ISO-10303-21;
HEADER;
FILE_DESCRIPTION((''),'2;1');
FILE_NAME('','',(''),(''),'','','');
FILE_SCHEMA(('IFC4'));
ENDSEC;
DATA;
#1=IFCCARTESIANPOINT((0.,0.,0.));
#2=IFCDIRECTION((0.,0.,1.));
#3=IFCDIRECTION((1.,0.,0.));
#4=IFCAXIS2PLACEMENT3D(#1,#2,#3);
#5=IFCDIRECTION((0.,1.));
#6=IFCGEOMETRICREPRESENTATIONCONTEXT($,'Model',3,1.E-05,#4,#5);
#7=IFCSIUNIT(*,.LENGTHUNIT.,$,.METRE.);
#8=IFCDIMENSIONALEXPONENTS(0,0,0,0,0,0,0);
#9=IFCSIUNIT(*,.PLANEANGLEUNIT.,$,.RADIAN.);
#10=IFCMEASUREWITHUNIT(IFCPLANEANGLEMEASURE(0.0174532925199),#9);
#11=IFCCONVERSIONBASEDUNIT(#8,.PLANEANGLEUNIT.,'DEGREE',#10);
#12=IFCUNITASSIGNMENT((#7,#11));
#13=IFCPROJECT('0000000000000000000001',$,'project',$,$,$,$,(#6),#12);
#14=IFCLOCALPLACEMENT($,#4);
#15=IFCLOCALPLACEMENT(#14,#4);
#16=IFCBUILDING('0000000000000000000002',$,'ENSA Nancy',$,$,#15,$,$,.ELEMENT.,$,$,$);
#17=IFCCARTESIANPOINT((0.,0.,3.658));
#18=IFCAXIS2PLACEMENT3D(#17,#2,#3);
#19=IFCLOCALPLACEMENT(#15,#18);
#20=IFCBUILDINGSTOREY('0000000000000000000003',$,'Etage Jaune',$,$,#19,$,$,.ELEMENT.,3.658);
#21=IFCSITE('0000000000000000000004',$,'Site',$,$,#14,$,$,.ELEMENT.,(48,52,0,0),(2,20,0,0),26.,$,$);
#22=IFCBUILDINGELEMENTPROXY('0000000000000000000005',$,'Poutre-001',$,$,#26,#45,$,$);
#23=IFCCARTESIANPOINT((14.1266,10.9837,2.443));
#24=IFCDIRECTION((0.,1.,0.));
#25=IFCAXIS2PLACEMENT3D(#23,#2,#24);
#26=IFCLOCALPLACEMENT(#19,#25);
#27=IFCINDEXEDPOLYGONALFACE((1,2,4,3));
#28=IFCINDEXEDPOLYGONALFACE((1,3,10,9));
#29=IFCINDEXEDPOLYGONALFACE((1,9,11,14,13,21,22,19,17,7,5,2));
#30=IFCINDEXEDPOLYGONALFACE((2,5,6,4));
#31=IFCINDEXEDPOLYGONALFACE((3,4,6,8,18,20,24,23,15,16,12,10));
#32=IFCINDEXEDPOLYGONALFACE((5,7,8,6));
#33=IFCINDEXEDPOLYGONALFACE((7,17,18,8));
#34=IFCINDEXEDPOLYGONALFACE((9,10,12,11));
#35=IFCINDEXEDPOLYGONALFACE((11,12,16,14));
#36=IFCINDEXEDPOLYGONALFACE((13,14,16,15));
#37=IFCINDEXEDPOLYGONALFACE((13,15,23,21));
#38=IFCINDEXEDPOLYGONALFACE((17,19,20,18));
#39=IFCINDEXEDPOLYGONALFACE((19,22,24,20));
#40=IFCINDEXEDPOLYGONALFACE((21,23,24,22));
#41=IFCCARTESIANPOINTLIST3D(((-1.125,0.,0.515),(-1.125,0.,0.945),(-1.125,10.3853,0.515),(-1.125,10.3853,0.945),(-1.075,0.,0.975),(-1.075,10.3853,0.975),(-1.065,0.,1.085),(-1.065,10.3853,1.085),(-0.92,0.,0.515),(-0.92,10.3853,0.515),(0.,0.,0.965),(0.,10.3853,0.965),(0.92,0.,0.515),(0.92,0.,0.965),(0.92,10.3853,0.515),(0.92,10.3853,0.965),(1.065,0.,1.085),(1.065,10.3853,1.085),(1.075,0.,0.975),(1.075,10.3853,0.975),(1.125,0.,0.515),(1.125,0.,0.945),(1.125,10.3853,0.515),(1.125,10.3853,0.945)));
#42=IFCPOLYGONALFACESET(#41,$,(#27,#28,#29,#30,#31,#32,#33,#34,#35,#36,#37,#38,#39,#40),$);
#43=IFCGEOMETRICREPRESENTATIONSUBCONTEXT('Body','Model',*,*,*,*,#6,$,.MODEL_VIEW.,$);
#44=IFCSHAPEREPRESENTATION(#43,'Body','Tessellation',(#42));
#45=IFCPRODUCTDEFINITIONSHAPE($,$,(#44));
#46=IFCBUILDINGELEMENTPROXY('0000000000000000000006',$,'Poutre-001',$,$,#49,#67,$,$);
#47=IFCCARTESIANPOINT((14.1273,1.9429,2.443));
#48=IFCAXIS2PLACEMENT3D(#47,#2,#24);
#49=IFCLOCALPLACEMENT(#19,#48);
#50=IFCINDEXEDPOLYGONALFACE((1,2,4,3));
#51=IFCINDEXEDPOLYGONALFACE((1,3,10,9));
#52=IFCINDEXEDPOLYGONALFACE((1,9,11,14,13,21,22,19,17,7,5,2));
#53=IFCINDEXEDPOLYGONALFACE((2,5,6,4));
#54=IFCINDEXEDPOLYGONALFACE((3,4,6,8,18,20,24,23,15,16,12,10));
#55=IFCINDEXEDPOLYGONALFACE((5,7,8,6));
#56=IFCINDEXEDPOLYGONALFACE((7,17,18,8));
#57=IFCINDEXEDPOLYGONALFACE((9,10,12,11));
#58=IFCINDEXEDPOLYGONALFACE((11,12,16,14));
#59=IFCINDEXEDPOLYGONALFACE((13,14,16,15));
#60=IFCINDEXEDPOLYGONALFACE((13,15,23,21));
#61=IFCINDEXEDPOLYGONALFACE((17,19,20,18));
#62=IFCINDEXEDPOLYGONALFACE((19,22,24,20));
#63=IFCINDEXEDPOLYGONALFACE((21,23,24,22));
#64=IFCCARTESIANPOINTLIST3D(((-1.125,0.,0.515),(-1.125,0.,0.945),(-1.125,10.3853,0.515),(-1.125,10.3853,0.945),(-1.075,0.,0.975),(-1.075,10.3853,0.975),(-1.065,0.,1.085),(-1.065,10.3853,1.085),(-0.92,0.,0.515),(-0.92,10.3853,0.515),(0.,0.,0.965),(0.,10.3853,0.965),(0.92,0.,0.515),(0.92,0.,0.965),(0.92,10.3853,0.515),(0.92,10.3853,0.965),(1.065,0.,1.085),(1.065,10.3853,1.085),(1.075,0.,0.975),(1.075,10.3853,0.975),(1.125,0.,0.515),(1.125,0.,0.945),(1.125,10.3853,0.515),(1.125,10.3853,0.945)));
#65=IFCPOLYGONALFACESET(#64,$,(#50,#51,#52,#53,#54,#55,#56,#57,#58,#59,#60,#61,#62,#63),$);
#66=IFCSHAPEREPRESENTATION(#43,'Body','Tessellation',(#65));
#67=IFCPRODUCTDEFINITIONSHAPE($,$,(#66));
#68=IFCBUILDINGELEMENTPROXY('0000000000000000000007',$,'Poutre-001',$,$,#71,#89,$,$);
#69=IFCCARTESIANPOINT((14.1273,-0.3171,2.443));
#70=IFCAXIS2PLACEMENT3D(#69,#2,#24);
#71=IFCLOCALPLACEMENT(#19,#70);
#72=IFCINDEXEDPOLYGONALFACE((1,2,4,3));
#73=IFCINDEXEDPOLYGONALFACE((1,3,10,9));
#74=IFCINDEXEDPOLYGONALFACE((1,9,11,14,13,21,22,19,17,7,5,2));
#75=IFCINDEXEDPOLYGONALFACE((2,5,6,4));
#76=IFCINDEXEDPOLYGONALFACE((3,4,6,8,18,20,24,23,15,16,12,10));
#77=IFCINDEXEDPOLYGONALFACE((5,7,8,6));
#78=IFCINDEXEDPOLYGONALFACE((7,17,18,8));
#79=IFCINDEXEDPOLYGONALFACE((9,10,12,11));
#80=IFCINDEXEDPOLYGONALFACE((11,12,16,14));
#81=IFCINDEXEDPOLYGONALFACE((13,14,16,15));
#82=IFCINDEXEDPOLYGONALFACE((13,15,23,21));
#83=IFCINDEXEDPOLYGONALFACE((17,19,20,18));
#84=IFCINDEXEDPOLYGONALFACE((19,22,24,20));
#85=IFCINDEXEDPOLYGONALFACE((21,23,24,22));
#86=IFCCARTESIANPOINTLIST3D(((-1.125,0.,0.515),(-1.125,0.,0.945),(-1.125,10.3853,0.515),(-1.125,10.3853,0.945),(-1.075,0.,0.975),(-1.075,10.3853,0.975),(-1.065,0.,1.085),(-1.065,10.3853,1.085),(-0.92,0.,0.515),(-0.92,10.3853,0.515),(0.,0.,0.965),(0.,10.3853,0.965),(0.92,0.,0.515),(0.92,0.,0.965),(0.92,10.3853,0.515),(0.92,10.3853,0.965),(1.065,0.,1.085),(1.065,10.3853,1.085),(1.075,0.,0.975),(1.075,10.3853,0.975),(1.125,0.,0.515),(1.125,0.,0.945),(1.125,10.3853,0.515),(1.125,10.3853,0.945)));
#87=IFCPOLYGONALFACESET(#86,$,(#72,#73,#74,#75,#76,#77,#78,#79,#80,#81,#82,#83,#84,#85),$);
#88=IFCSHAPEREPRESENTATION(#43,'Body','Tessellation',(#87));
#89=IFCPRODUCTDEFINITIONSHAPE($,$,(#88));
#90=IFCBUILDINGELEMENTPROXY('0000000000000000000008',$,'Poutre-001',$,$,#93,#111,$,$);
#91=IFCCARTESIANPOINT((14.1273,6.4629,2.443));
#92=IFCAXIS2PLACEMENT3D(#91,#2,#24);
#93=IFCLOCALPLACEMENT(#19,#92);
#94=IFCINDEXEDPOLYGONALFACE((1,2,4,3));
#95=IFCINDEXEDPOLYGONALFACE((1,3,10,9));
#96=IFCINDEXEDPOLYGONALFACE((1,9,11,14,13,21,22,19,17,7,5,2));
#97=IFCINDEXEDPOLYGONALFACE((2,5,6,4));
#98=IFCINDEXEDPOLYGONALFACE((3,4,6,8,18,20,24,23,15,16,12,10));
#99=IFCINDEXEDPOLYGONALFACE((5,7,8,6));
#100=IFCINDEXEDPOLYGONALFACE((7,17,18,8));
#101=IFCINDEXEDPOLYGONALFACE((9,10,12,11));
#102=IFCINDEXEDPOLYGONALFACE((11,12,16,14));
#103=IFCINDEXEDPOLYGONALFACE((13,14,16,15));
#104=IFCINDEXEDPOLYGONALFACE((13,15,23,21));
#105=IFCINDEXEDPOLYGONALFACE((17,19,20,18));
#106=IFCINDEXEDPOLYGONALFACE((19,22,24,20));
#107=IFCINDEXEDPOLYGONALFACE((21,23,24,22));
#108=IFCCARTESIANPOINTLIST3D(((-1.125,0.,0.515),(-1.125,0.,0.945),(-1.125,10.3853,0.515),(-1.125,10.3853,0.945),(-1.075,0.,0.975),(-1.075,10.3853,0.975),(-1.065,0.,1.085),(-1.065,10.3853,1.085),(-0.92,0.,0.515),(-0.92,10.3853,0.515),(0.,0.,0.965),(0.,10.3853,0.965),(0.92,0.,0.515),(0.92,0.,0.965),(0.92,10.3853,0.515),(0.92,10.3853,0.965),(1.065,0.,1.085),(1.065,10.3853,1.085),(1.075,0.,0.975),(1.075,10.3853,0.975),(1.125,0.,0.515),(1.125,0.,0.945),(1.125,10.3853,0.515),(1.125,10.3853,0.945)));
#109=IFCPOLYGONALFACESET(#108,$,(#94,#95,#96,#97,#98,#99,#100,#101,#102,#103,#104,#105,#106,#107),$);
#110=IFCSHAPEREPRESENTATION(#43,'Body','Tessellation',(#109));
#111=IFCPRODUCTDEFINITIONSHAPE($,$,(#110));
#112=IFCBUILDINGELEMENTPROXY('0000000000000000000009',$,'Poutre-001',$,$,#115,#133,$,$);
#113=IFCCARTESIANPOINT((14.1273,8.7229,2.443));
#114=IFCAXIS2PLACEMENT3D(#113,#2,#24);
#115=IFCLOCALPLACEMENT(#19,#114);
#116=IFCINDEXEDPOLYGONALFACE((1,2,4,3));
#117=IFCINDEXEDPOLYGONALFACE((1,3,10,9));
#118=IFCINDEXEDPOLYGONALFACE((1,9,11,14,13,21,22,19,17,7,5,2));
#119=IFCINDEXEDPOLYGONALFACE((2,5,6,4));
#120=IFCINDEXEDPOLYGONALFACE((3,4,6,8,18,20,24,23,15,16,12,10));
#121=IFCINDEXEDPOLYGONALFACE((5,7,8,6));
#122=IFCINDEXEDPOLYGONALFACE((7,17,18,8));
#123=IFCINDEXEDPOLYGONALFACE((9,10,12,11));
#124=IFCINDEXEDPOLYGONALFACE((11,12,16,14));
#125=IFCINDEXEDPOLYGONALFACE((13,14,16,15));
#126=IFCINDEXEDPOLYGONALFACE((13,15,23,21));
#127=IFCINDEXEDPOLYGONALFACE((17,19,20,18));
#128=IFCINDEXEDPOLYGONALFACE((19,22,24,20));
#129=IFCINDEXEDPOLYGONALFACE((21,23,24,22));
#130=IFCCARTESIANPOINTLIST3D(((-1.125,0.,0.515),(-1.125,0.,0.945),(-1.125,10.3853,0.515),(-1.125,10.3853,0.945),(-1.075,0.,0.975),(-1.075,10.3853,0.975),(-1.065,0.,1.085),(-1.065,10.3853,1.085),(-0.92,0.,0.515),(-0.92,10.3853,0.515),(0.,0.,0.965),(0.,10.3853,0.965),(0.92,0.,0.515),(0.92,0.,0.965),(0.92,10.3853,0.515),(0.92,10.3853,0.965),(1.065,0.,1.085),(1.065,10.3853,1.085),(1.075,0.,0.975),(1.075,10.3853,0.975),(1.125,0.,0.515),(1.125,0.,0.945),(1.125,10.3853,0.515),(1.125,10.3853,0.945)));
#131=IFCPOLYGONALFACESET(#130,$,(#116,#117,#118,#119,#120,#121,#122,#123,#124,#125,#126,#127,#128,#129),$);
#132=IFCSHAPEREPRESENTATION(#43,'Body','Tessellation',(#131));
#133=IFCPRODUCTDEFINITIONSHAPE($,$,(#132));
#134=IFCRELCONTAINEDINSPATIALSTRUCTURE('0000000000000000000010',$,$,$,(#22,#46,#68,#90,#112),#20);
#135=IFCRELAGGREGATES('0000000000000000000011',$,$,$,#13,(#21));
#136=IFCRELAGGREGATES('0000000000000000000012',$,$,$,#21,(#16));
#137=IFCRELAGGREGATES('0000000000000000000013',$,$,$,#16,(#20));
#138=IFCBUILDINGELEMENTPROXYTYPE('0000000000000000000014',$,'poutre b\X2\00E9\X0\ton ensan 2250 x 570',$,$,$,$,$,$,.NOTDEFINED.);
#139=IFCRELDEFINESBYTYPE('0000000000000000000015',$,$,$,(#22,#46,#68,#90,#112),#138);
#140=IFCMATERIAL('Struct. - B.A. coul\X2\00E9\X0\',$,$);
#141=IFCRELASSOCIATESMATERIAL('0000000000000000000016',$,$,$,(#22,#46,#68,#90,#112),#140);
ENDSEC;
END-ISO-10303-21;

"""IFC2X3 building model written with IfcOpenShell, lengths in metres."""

from ifc_helpers import new_model, entity, si_unit, converted_unit, direction, frame, origin_with_axes, place, context, subcontext, project, spatial, polyline, outline, extrude, material, type_object, element, save


model = new_model("IFC2X3")

# Units and contexts
model_context = context("Model", 3, precision=1e-05, world=origin_with_axes(), true_north=direction((0.0, 1.0)))
body_context = subcontext(model_context, "Body", "Model", "MODEL_VIEW")
ifc_project = project(units=[si_unit("LENGTHUNIT", "METRE"), converted_unit("PLANEANGLEUNIT", "DEGREE", entity("IfcPlaneAngleMeasure", 0.0174532925199), si_unit("PLANEANGLEUNIT", "RADIAN"), dimensions=[0, 0, 0, 0, 0, 0, 0])], contexts=[model_context])

# Site, building, storey
site_placement = place(None, origin_with_axes())
site = spatial("IfcSite", under=ifc_project, at=site_placement, Name="Site", CompositionType="ELEMENT", RefLatitude=(48, 52, 0, 0), RefLongitude=(2, 20, 0, 0), RefElevation=26.0)
building_placement = place(site_placement, origin_with_axes())
building = spatial("IfcBuilding", under=site, at=building_placement, Name="ENSA Nancy", CompositionType="ELEMENT")
storey_placement = place(building_placement, frame((0.0, 0.0, 3.658), z_axis=(0.0, 0.0, 1.0), x_axis=(1.0, 0.0, 0.0)))
storey = spatial("IfcBuildingStorey", under=building, at=storey_placement, Name="Etage Jaune", CompositionType="ELEMENT", Elevation=3.658)

# Building element proxies
ifc_material_1 = material(Name="Struct. - B.A. coulé")
building_element_proxy_type_1 = type_object("IfcBuildingElementProxyType", Name="poutre béton ensan 2250 x 570", PredefinedType="NOTDEFINED")
for number, where, z_axis, x_axis, name in (
    (1, (14.1266, 10.9837, 2.443), (0.0, 0.0, 1.0), (0.0, 1.0, 0.0), "Poutre-001"),
    (2, (14.1273, 1.9429, 2.443), (0.0, 0.0, 1.0), (0.0, 1.0, 0.0), "Poutre-001"),
    (3, (14.1273, -0.3171, 2.443), (0.0, 0.0, 1.0), (0.0, 1.0, 0.0), "Poutre-001"),
    (4, (14.1273, 6.4629, 2.443), (0.0, 0.0, 1.0), (0.0, 1.0, 0.0), "Poutre-001"),
    (5, (14.1273, 8.7229, 2.443), (0.0, 0.0, 1.0), (0.0, 1.0, 0.0), "Poutre-001"),
):
    element("IfcBuildingElementProxy", number, at=place(storey_placement, frame(where, z_axis=z_axis, x_axis=x_axis)), inside=storey, type_object=building_element_proxy_type_1, material=ifc_material_1, Name=name, context=body_context, shape_type="SweptSolid", body=[
        extrude(outline(polyline([(-1.065, 1.085), (-1.075, 0.975), (-1.125, 0.945), (-1.125, 0.515), (-0.92, 0.515), (0.0, 0.965), (0.92, 0.965), (0.92, 0.515), (1.125, 0.515), (1.125, 0.945), (1.075, 0.975), (1.065, 1.085), (-1.065, 1.085)])), frame((0.0, 10.3853, 0.0), z_axis=(0.0, -1.0, 0.0), x_axis=(1.0, 0.0, 0.0)), (0.0, 0.0, 1.0), 10.3853),
    ])

save(model, "model.ifc")
